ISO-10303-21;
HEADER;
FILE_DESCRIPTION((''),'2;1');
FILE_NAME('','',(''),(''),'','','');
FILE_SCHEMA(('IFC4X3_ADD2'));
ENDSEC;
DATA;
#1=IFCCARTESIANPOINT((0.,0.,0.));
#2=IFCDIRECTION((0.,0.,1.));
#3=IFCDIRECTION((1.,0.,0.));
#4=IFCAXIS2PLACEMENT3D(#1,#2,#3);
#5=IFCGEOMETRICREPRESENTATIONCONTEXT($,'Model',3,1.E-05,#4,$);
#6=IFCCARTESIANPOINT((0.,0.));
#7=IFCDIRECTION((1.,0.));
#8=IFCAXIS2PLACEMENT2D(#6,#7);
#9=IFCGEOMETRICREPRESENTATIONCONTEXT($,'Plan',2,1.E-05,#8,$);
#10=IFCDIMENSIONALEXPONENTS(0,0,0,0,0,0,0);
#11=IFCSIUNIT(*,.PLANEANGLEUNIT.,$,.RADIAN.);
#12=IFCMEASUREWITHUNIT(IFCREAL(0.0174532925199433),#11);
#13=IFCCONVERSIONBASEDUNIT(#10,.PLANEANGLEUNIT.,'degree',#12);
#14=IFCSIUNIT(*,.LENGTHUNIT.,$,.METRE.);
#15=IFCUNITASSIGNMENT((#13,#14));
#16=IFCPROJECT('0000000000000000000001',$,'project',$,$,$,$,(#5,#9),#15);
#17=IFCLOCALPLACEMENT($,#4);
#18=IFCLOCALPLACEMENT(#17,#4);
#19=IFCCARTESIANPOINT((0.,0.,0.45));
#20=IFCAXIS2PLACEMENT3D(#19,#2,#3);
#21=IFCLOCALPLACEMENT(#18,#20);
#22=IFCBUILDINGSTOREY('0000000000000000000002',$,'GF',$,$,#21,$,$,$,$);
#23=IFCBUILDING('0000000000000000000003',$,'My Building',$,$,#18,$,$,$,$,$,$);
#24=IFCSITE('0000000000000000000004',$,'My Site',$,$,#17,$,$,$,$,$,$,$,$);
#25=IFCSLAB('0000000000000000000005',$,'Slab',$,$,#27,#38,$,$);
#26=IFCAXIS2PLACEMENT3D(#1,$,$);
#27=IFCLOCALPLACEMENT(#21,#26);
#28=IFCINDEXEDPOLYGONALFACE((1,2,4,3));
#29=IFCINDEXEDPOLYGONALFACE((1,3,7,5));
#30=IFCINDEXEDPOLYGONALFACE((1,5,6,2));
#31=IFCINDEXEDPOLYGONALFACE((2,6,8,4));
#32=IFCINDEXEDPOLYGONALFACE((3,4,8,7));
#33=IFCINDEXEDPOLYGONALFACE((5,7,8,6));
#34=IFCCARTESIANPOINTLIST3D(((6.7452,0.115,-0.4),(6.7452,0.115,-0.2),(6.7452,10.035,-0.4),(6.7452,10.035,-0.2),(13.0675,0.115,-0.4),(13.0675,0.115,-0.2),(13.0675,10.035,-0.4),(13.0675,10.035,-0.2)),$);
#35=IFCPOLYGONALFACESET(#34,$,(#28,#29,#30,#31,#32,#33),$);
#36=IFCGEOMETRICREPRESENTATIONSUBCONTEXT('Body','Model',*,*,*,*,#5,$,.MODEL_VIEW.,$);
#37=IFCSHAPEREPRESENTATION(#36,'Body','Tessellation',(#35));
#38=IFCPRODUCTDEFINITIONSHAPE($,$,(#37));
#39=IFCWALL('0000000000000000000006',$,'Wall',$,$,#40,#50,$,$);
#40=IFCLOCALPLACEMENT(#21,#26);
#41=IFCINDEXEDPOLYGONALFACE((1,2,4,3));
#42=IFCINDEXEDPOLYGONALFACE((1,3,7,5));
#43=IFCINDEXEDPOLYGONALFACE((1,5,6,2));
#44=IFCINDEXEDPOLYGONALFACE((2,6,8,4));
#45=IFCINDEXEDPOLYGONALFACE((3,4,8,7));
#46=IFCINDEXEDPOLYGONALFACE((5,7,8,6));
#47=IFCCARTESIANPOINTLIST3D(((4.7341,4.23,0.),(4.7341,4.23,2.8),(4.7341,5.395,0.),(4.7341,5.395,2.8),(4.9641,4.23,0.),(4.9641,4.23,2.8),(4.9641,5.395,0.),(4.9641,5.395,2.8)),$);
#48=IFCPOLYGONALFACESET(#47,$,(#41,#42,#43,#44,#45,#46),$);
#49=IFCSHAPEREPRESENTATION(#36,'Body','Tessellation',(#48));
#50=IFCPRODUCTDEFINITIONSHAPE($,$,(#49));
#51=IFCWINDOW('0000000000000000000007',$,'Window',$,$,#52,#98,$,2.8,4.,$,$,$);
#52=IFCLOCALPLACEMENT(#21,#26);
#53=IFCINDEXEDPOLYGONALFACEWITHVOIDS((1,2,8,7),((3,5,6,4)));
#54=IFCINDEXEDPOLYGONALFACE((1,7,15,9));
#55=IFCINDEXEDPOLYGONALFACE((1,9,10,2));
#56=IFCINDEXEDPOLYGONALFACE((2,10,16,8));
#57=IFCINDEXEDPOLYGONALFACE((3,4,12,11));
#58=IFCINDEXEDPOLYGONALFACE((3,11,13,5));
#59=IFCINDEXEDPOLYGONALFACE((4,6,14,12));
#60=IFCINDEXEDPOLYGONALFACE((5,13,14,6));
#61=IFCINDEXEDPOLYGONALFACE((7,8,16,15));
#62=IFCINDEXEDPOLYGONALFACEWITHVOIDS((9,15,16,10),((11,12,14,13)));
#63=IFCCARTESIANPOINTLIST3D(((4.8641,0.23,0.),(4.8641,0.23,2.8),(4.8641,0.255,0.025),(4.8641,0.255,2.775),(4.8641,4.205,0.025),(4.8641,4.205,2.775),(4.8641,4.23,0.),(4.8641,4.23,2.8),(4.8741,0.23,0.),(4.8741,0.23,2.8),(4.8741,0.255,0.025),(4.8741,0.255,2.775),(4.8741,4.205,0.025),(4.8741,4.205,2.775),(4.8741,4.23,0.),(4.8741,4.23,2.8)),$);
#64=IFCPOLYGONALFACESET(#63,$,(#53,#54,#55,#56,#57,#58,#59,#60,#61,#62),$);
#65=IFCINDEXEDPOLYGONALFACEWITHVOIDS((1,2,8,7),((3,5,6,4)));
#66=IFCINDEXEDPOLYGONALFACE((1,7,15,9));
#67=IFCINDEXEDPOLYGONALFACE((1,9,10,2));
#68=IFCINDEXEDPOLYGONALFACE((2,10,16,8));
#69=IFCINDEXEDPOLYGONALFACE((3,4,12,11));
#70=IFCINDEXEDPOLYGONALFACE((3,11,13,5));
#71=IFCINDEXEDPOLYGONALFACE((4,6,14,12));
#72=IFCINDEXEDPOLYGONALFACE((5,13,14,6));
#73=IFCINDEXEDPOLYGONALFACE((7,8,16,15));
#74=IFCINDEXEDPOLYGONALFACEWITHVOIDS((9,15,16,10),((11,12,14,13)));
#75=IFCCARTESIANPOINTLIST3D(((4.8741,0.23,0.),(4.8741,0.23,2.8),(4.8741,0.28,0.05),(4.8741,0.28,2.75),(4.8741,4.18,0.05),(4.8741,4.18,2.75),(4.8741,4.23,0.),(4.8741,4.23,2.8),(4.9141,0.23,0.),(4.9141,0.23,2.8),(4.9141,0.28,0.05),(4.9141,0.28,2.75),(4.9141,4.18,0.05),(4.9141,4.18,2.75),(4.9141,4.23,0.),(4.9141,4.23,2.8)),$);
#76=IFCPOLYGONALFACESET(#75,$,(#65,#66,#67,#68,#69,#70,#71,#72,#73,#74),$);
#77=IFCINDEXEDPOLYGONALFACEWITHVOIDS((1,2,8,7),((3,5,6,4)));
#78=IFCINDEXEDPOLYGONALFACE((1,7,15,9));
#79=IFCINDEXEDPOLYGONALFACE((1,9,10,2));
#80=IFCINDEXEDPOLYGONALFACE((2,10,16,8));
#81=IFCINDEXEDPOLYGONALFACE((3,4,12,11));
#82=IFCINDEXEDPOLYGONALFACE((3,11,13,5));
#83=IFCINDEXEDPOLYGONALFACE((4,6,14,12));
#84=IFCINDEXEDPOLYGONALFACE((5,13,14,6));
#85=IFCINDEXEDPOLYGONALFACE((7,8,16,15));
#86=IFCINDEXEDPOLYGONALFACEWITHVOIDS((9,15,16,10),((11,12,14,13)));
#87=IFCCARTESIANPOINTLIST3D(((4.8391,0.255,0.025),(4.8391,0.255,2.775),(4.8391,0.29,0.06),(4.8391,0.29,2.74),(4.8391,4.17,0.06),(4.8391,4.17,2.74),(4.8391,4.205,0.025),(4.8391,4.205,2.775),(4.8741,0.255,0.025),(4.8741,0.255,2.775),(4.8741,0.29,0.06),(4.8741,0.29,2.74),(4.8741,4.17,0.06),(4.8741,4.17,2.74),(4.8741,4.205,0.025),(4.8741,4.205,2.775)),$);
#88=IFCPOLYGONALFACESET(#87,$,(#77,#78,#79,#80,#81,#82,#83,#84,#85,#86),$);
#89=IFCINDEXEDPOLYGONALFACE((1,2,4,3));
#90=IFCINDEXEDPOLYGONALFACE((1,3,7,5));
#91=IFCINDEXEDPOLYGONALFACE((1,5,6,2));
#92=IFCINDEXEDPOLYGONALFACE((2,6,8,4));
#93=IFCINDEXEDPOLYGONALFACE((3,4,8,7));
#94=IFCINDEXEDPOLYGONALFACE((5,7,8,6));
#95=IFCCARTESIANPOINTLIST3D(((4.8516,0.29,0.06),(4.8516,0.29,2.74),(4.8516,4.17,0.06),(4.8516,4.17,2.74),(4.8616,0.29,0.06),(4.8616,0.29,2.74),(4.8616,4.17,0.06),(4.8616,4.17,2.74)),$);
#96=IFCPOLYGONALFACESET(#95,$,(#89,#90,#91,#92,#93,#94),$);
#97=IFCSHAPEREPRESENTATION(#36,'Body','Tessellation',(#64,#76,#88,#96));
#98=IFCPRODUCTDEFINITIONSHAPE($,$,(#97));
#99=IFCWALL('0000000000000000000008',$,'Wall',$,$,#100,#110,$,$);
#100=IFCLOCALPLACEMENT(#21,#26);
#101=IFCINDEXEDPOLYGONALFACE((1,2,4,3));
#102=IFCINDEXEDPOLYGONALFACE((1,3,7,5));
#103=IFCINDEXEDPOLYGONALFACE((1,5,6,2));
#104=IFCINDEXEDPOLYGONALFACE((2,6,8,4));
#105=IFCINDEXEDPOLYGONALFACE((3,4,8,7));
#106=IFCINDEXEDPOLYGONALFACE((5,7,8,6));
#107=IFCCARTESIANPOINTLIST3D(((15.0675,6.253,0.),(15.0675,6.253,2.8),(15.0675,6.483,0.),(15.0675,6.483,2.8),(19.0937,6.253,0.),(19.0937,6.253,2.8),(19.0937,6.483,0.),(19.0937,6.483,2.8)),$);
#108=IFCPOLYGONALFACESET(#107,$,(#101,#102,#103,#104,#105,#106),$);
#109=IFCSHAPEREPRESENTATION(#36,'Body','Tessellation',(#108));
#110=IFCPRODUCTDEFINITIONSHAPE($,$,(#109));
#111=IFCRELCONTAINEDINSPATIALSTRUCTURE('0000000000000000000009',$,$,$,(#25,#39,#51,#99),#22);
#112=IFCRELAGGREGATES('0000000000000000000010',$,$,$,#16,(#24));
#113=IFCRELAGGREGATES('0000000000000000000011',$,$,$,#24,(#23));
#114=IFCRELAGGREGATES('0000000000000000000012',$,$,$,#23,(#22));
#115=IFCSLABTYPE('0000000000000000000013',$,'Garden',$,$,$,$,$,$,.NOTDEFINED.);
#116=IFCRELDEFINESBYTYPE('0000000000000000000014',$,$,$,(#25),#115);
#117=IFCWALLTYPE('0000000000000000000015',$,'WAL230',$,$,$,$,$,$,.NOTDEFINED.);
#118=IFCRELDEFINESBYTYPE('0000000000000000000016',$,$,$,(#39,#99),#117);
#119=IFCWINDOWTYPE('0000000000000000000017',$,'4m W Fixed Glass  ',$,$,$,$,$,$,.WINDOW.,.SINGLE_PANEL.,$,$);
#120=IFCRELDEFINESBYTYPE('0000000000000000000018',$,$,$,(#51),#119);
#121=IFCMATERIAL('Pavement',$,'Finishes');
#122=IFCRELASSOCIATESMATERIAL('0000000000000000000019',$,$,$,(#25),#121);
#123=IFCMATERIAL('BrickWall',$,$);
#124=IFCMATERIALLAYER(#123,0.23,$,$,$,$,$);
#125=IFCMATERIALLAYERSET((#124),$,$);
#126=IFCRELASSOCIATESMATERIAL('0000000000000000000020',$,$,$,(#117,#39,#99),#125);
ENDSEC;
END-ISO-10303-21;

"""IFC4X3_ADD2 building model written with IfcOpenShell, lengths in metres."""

from ifc_helpers import new_model, entity, si_unit, converted_unit, frame, origin_with_axes, origin_2d_with_axis, place, context, subcontext, project, spatial, line, indexed_curve, outline, extrude, shape, source, transform, mapped, material, layer, layer_set, layer_usage, type_object, type_shapes, element, fill, save


model = new_model("IFC4X3_ADD2")

# Units and contexts
model_context = context("Model", 3, precision=1e-05, world=origin_with_axes())
plan_context = context("Plan", 2, precision=1e-05, world=origin_2d_with_axis())
body_context_1 = subcontext(model_context, "Body", "Model", "MODEL_VIEW")
body_context_2 = subcontext(plan_context, "Body", "Plan", "PLAN_VIEW")
ifc_project = project(units=[converted_unit("PLANEANGLEUNIT", "degree", entity("IfcReal", 0.0174532925199433), si_unit("PLANEANGLEUNIT", "RADIAN"), dimensions=[0, 0, 0, 0, 0, 0, 0]), si_unit("LENGTHUNIT", "METRE")], contexts=[model_context, plan_context])

# Site, building, storey
site_placement = place(None, origin_with_axes())
site = spatial("IfcSite", under=ifc_project, at=site_placement, Name="My Site")
building_placement = place(site_placement, origin_with_axes())
building = spatial("IfcBuilding", under=site, at=building_placement, Name="My Building")
storey_placement = place(building_placement, frame((0.0, 0.0, 0.45), z_axis=(0.0, 0.0, 1.0), x_axis=(1.0, 0.0, 0.0)))
storey = spatial("IfcBuildingStorey", under=building, at=storey_placement, Name="GF")

# Slab
ifc_material_1 = material(Name="Pavement", Category="Finishes")
slab_type = type_object("IfcSlabType", Name="Garden", PredefinedType="NOTDEFINED")
slab_placement = place(storey_placement, frame((6.7452, 0.115, -0.4), z_axis=(0.0, 0.0, 1.0), x_axis=(1.0, 0.0, 0.0)))
element("IfcSlab", 1, at=slab_placement, inside=storey, type_object=slab_type, material=ifc_material_1, Name="Slab", context=body_context_1, shape_type="SweptSolid", body=[
    extrude(outline(indexed_curve([(0.0, 9.92), (0.0, 0.0), (6.3223, 0.0), (6.3223, 9.92)], segments=[line(4, 1), line(1, 2), line(2, 3), line(3, 4)], self_intersect=False)), None, (0.0, 0.0, 1.0), 0.2),
])

# Wall, opening, window
ifc_material_2 = material(Name="BrickWall")
ifc_layer_1 = layer(ifc_material_2, 0.23)
ifc_layer_set_1 = layer_set([ifc_layer_1])
ifc_layer_usage_1 = layer_usage(ifc_layer_set_1, "AXIS2", "POSITIVE", 0.0)
wall_type_1 = type_object("IfcWallType", Name="WAL230", PredefinedType="NOTDEFINED", material=ifc_layer_set_1)
wall_1_placement = place(storey_placement, frame((4.9641, 4.23, 0.0), z_axis=(0.0, 0.0, 1.0), x_axis=(0.0, 1.0, 0.0)))
wall_1 = element("IfcWall", 2, at=wall_1_placement, inside=storey, type_object=wall_type_1, material=ifc_layer_usage_1, Name="Wall", context=body_context_1, shape_type="SweptSolid", body=[
    extrude(outline(indexed_curve([(0.0, 0.0), (0.0, 0.23), (1.165, 0.23), (1.165, 0.0), (0.0, 0.0)], self_intersect=False)), origin_with_axes(), (0.0, 0.0, 1.0), 2.8),
])
shared_shape_1 = source(origin_with_axes(), body_context_1, "Body", "SweptSolid", [
    extrude(outline(indexed_curve([(0.0, 0.0), (4.0, 0.0), (4.0, 2.8), (0.0, 2.8)], segments=[line(1, 2, 3, 4, 1)])), frame((0.0, -0.6, 0.0), z_axis=(0.0, -1.0, 0.0), x_axis=(1.0, 0.0, 0.0)), (0.0, 0.0, -1.0), 1.2),
])
opening_1_placement = place(wall_1_placement, frame((-4.0, 0.0, 0.0), z_axis=(0.0, 0.0, 1.0), x_axis=(1.0, 0.0, 0.0)))
opening_1 = element("IfcOpeningElement", 3, at=opening_1_placement, cuts=wall_1, PredefinedType="OPENING", context=body_context_1, shape_type="MappedRepresentation", body=[
    mapped(shared_shape_1, transform((0.0, 0.0, 0.0), x_axis=(1.0, 0.0, 0.0), y_axis=(0.0, 1.0, 0.0), z_axis=(0.0, 0.0, 1.0), scale=1.0)),
])
window_type_1 = type_object("IfcWindowType", Name="4m W Fixed Glass  ", PartitioningType="SINGLE_PANEL", PredefinedType="WINDOW")
shared_shape_2 = source(origin_with_axes(), body_context_1, "Body", "SweptSolid", [
    extrude(outline(indexed_curve([(0.0, 0.0), (4.0, 0.0), (4.0, 2.8), (0.0, 2.8)], segments=[line(1, 2, 3, 4, 1)]), holes=[indexed_curve([(0.025, 0.025), (3.975, 0.025), (3.975, 2.775), (0.025, 2.775)], segments=[line(1, 2, 3, 4, 1)])]), frame((0.0, 0.09, 0.0), z_axis=(0.0, -1.0, 0.0), x_axis=(1.0, 0.0, 0.0)), (0.0, 0.0, -1.0), 0.01),
    extrude(outline(indexed_curve([(0.0, 0.0), (4.0, 0.0), (4.0, 2.8), (0.0, 2.8)], segments=[line(1, 2, 3, 4, 1)]), holes=[indexed_curve([(0.05, 0.05), (3.95, 0.05), (3.95, 2.75), (0.05, 2.75)], segments=[line(1, 2, 3, 4, 1)])]), frame((0.0, 0.05, 0.0), z_axis=(0.0, -1.0, 0.0), x_axis=(1.0, 0.0, 0.0)), (0.0, 0.0, -1.0), 0.04),
    extrude(outline(indexed_curve([(0.0, 0.0), (3.95, 0.0), (3.95, 2.75), (0.0, 2.75)], segments=[line(1, 2, 3, 4, 1)]), holes=[indexed_curve([(0.035, 0.035), (3.915, 0.035), (3.915, 2.715), (0.035, 2.715)], segments=[line(1, 2, 3, 4, 1)])]), frame((0.025, 0.09, 0.025), z_axis=(0.0, -1.0, 0.0), x_axis=(1.0, 0.0, 0.0)), (0.0, 0.0, -1.0), 0.035),
    extrude(outline(indexed_curve([(0.035, 0.035), (3.915, 0.035), (3.915, 2.715), (0.035, 2.715)], segments=[line(1, 2, 3, 4, 1)])), frame((0.025, 0.1025, 0.025), z_axis=(0.0, -1.0, 0.0), x_axis=(1.0, 0.0, 0.0)), (0.0, 0.0, -1.0), 0.01),
])
shared_shape_3 = source(origin_with_axes(), body_context_2, "Body", "Curve2D", [
    entity("IfcIndexedPolyCurve", entity("IfcCartesianPointList2D", [[0.05, 0.05], [3.95, 0.05]])),
    entity("IfcIndexedPolyCurve", entity("IfcCartesianPointList2D", [[0.0, 0.1], [0.025, 0.1], [0.025, 0.09], [0.05, 0.09], [0.05, 0.05], [0.0, 0.05]]), [entity("IfcLineIndex", [1, 2, 3, 4, 5, 6, 1])]),
    entity("IfcIndexedPolyCurve", entity("IfcCartesianPointList2D", [[4.0, 0.1], [3.975, 0.1], [3.975, 0.09], [3.95, 0.09], [3.95, 0.05], [4.0, 0.05]]), [entity("IfcLineIndex", [1, 2, 3, 4, 5, 6, 1])]),
    entity("IfcIndexedPolyCurve", entity("IfcCartesianPointList2D", [[0.025, 0.09], [0.06, 0.09], [0.06, 0.125], [0.025, 0.125]]), [entity("IfcLineIndex", [1, 2, 3, 4, 1])]),
    entity("IfcIndexedPolyCurve", entity("IfcCartesianPointList2D", [[3.975, 0.09], [3.94, 0.09], [3.94, 0.125], [3.975, 0.125]]), [entity("IfcLineIndex", [1, 2, 3, 4, 1])]),
    entity("IfcIndexedPolyCurve", entity("IfcCartesianPointList2D", [[0.06, 0.09], [3.94, 0.09]])),
    entity("IfcIndexedPolyCurve", entity("IfcCartesianPointList2D", [[0.06, 0.125], [3.94, 0.125]])),
    entity("IfcIndexedPolyCurve", entity("IfcCartesianPointList2D", [[0.06, 0.1075], [3.94, 0.1075]])),
])
type_shapes(window_type_1, [shared_shape_2, shared_shape_3])
window_1_placement = place(opening_1_placement, origin_with_axes())
window_1 = element("IfcWindow", 4, at=window_1_placement, inside=storey, type_object=window_type_1, Name="Window", OverallHeight=2.8, OverallWidth=4.0, shapes=[
    shape(body_context_1, "Body", "MappedRepresentation", [mapped(shared_shape_2, transform((0.0, 0.0, 0.0), x_axis=(1.0, 0.0, 0.0), y_axis=(0.0, 1.0, 0.0), z_axis=(0.0, 0.0, 1.0), scale=1.0))]),
    shape(body_context_2, "Body", "MappedRepresentation", [mapped(shared_shape_3, transform((0.0, 0.0, 0.0), x_axis=(1.0, 0.0, 0.0), y_axis=(0.0, 1.0, 0.0), z_axis=(0.0, 0.0, 1.0), scale=1.0))]),
])
fill(opening_1, window_1)

# Wall
ifc_layer_usage_2 = layer_usage(ifc_layer_set_1, "AXIS2", "POSITIVE", 0.0)
wall_2_placement = place(storey_placement, frame((15.0675, 6.253, 0.0), z_axis=(0.0, 0.0, 1.0), x_axis=(1.0, 0.0, 0.0)))
element("IfcWall", 5, at=wall_2_placement, inside=storey, type_object=wall_type_1, material=ifc_layer_usage_2, Name="Wall", context=body_context_1, shape_type="SweptSolid", body=[
    extrude(outline(indexed_curve([(0.0, 0.0), (0.0, 0.23), (4.0262, 0.23), (4.0262, 0.0), (0.0, 0.0)], self_intersect=False)), origin_with_axes(), (0.0, 0.0, 1.0), 2.8),
])

save(model, "model.ifc")
